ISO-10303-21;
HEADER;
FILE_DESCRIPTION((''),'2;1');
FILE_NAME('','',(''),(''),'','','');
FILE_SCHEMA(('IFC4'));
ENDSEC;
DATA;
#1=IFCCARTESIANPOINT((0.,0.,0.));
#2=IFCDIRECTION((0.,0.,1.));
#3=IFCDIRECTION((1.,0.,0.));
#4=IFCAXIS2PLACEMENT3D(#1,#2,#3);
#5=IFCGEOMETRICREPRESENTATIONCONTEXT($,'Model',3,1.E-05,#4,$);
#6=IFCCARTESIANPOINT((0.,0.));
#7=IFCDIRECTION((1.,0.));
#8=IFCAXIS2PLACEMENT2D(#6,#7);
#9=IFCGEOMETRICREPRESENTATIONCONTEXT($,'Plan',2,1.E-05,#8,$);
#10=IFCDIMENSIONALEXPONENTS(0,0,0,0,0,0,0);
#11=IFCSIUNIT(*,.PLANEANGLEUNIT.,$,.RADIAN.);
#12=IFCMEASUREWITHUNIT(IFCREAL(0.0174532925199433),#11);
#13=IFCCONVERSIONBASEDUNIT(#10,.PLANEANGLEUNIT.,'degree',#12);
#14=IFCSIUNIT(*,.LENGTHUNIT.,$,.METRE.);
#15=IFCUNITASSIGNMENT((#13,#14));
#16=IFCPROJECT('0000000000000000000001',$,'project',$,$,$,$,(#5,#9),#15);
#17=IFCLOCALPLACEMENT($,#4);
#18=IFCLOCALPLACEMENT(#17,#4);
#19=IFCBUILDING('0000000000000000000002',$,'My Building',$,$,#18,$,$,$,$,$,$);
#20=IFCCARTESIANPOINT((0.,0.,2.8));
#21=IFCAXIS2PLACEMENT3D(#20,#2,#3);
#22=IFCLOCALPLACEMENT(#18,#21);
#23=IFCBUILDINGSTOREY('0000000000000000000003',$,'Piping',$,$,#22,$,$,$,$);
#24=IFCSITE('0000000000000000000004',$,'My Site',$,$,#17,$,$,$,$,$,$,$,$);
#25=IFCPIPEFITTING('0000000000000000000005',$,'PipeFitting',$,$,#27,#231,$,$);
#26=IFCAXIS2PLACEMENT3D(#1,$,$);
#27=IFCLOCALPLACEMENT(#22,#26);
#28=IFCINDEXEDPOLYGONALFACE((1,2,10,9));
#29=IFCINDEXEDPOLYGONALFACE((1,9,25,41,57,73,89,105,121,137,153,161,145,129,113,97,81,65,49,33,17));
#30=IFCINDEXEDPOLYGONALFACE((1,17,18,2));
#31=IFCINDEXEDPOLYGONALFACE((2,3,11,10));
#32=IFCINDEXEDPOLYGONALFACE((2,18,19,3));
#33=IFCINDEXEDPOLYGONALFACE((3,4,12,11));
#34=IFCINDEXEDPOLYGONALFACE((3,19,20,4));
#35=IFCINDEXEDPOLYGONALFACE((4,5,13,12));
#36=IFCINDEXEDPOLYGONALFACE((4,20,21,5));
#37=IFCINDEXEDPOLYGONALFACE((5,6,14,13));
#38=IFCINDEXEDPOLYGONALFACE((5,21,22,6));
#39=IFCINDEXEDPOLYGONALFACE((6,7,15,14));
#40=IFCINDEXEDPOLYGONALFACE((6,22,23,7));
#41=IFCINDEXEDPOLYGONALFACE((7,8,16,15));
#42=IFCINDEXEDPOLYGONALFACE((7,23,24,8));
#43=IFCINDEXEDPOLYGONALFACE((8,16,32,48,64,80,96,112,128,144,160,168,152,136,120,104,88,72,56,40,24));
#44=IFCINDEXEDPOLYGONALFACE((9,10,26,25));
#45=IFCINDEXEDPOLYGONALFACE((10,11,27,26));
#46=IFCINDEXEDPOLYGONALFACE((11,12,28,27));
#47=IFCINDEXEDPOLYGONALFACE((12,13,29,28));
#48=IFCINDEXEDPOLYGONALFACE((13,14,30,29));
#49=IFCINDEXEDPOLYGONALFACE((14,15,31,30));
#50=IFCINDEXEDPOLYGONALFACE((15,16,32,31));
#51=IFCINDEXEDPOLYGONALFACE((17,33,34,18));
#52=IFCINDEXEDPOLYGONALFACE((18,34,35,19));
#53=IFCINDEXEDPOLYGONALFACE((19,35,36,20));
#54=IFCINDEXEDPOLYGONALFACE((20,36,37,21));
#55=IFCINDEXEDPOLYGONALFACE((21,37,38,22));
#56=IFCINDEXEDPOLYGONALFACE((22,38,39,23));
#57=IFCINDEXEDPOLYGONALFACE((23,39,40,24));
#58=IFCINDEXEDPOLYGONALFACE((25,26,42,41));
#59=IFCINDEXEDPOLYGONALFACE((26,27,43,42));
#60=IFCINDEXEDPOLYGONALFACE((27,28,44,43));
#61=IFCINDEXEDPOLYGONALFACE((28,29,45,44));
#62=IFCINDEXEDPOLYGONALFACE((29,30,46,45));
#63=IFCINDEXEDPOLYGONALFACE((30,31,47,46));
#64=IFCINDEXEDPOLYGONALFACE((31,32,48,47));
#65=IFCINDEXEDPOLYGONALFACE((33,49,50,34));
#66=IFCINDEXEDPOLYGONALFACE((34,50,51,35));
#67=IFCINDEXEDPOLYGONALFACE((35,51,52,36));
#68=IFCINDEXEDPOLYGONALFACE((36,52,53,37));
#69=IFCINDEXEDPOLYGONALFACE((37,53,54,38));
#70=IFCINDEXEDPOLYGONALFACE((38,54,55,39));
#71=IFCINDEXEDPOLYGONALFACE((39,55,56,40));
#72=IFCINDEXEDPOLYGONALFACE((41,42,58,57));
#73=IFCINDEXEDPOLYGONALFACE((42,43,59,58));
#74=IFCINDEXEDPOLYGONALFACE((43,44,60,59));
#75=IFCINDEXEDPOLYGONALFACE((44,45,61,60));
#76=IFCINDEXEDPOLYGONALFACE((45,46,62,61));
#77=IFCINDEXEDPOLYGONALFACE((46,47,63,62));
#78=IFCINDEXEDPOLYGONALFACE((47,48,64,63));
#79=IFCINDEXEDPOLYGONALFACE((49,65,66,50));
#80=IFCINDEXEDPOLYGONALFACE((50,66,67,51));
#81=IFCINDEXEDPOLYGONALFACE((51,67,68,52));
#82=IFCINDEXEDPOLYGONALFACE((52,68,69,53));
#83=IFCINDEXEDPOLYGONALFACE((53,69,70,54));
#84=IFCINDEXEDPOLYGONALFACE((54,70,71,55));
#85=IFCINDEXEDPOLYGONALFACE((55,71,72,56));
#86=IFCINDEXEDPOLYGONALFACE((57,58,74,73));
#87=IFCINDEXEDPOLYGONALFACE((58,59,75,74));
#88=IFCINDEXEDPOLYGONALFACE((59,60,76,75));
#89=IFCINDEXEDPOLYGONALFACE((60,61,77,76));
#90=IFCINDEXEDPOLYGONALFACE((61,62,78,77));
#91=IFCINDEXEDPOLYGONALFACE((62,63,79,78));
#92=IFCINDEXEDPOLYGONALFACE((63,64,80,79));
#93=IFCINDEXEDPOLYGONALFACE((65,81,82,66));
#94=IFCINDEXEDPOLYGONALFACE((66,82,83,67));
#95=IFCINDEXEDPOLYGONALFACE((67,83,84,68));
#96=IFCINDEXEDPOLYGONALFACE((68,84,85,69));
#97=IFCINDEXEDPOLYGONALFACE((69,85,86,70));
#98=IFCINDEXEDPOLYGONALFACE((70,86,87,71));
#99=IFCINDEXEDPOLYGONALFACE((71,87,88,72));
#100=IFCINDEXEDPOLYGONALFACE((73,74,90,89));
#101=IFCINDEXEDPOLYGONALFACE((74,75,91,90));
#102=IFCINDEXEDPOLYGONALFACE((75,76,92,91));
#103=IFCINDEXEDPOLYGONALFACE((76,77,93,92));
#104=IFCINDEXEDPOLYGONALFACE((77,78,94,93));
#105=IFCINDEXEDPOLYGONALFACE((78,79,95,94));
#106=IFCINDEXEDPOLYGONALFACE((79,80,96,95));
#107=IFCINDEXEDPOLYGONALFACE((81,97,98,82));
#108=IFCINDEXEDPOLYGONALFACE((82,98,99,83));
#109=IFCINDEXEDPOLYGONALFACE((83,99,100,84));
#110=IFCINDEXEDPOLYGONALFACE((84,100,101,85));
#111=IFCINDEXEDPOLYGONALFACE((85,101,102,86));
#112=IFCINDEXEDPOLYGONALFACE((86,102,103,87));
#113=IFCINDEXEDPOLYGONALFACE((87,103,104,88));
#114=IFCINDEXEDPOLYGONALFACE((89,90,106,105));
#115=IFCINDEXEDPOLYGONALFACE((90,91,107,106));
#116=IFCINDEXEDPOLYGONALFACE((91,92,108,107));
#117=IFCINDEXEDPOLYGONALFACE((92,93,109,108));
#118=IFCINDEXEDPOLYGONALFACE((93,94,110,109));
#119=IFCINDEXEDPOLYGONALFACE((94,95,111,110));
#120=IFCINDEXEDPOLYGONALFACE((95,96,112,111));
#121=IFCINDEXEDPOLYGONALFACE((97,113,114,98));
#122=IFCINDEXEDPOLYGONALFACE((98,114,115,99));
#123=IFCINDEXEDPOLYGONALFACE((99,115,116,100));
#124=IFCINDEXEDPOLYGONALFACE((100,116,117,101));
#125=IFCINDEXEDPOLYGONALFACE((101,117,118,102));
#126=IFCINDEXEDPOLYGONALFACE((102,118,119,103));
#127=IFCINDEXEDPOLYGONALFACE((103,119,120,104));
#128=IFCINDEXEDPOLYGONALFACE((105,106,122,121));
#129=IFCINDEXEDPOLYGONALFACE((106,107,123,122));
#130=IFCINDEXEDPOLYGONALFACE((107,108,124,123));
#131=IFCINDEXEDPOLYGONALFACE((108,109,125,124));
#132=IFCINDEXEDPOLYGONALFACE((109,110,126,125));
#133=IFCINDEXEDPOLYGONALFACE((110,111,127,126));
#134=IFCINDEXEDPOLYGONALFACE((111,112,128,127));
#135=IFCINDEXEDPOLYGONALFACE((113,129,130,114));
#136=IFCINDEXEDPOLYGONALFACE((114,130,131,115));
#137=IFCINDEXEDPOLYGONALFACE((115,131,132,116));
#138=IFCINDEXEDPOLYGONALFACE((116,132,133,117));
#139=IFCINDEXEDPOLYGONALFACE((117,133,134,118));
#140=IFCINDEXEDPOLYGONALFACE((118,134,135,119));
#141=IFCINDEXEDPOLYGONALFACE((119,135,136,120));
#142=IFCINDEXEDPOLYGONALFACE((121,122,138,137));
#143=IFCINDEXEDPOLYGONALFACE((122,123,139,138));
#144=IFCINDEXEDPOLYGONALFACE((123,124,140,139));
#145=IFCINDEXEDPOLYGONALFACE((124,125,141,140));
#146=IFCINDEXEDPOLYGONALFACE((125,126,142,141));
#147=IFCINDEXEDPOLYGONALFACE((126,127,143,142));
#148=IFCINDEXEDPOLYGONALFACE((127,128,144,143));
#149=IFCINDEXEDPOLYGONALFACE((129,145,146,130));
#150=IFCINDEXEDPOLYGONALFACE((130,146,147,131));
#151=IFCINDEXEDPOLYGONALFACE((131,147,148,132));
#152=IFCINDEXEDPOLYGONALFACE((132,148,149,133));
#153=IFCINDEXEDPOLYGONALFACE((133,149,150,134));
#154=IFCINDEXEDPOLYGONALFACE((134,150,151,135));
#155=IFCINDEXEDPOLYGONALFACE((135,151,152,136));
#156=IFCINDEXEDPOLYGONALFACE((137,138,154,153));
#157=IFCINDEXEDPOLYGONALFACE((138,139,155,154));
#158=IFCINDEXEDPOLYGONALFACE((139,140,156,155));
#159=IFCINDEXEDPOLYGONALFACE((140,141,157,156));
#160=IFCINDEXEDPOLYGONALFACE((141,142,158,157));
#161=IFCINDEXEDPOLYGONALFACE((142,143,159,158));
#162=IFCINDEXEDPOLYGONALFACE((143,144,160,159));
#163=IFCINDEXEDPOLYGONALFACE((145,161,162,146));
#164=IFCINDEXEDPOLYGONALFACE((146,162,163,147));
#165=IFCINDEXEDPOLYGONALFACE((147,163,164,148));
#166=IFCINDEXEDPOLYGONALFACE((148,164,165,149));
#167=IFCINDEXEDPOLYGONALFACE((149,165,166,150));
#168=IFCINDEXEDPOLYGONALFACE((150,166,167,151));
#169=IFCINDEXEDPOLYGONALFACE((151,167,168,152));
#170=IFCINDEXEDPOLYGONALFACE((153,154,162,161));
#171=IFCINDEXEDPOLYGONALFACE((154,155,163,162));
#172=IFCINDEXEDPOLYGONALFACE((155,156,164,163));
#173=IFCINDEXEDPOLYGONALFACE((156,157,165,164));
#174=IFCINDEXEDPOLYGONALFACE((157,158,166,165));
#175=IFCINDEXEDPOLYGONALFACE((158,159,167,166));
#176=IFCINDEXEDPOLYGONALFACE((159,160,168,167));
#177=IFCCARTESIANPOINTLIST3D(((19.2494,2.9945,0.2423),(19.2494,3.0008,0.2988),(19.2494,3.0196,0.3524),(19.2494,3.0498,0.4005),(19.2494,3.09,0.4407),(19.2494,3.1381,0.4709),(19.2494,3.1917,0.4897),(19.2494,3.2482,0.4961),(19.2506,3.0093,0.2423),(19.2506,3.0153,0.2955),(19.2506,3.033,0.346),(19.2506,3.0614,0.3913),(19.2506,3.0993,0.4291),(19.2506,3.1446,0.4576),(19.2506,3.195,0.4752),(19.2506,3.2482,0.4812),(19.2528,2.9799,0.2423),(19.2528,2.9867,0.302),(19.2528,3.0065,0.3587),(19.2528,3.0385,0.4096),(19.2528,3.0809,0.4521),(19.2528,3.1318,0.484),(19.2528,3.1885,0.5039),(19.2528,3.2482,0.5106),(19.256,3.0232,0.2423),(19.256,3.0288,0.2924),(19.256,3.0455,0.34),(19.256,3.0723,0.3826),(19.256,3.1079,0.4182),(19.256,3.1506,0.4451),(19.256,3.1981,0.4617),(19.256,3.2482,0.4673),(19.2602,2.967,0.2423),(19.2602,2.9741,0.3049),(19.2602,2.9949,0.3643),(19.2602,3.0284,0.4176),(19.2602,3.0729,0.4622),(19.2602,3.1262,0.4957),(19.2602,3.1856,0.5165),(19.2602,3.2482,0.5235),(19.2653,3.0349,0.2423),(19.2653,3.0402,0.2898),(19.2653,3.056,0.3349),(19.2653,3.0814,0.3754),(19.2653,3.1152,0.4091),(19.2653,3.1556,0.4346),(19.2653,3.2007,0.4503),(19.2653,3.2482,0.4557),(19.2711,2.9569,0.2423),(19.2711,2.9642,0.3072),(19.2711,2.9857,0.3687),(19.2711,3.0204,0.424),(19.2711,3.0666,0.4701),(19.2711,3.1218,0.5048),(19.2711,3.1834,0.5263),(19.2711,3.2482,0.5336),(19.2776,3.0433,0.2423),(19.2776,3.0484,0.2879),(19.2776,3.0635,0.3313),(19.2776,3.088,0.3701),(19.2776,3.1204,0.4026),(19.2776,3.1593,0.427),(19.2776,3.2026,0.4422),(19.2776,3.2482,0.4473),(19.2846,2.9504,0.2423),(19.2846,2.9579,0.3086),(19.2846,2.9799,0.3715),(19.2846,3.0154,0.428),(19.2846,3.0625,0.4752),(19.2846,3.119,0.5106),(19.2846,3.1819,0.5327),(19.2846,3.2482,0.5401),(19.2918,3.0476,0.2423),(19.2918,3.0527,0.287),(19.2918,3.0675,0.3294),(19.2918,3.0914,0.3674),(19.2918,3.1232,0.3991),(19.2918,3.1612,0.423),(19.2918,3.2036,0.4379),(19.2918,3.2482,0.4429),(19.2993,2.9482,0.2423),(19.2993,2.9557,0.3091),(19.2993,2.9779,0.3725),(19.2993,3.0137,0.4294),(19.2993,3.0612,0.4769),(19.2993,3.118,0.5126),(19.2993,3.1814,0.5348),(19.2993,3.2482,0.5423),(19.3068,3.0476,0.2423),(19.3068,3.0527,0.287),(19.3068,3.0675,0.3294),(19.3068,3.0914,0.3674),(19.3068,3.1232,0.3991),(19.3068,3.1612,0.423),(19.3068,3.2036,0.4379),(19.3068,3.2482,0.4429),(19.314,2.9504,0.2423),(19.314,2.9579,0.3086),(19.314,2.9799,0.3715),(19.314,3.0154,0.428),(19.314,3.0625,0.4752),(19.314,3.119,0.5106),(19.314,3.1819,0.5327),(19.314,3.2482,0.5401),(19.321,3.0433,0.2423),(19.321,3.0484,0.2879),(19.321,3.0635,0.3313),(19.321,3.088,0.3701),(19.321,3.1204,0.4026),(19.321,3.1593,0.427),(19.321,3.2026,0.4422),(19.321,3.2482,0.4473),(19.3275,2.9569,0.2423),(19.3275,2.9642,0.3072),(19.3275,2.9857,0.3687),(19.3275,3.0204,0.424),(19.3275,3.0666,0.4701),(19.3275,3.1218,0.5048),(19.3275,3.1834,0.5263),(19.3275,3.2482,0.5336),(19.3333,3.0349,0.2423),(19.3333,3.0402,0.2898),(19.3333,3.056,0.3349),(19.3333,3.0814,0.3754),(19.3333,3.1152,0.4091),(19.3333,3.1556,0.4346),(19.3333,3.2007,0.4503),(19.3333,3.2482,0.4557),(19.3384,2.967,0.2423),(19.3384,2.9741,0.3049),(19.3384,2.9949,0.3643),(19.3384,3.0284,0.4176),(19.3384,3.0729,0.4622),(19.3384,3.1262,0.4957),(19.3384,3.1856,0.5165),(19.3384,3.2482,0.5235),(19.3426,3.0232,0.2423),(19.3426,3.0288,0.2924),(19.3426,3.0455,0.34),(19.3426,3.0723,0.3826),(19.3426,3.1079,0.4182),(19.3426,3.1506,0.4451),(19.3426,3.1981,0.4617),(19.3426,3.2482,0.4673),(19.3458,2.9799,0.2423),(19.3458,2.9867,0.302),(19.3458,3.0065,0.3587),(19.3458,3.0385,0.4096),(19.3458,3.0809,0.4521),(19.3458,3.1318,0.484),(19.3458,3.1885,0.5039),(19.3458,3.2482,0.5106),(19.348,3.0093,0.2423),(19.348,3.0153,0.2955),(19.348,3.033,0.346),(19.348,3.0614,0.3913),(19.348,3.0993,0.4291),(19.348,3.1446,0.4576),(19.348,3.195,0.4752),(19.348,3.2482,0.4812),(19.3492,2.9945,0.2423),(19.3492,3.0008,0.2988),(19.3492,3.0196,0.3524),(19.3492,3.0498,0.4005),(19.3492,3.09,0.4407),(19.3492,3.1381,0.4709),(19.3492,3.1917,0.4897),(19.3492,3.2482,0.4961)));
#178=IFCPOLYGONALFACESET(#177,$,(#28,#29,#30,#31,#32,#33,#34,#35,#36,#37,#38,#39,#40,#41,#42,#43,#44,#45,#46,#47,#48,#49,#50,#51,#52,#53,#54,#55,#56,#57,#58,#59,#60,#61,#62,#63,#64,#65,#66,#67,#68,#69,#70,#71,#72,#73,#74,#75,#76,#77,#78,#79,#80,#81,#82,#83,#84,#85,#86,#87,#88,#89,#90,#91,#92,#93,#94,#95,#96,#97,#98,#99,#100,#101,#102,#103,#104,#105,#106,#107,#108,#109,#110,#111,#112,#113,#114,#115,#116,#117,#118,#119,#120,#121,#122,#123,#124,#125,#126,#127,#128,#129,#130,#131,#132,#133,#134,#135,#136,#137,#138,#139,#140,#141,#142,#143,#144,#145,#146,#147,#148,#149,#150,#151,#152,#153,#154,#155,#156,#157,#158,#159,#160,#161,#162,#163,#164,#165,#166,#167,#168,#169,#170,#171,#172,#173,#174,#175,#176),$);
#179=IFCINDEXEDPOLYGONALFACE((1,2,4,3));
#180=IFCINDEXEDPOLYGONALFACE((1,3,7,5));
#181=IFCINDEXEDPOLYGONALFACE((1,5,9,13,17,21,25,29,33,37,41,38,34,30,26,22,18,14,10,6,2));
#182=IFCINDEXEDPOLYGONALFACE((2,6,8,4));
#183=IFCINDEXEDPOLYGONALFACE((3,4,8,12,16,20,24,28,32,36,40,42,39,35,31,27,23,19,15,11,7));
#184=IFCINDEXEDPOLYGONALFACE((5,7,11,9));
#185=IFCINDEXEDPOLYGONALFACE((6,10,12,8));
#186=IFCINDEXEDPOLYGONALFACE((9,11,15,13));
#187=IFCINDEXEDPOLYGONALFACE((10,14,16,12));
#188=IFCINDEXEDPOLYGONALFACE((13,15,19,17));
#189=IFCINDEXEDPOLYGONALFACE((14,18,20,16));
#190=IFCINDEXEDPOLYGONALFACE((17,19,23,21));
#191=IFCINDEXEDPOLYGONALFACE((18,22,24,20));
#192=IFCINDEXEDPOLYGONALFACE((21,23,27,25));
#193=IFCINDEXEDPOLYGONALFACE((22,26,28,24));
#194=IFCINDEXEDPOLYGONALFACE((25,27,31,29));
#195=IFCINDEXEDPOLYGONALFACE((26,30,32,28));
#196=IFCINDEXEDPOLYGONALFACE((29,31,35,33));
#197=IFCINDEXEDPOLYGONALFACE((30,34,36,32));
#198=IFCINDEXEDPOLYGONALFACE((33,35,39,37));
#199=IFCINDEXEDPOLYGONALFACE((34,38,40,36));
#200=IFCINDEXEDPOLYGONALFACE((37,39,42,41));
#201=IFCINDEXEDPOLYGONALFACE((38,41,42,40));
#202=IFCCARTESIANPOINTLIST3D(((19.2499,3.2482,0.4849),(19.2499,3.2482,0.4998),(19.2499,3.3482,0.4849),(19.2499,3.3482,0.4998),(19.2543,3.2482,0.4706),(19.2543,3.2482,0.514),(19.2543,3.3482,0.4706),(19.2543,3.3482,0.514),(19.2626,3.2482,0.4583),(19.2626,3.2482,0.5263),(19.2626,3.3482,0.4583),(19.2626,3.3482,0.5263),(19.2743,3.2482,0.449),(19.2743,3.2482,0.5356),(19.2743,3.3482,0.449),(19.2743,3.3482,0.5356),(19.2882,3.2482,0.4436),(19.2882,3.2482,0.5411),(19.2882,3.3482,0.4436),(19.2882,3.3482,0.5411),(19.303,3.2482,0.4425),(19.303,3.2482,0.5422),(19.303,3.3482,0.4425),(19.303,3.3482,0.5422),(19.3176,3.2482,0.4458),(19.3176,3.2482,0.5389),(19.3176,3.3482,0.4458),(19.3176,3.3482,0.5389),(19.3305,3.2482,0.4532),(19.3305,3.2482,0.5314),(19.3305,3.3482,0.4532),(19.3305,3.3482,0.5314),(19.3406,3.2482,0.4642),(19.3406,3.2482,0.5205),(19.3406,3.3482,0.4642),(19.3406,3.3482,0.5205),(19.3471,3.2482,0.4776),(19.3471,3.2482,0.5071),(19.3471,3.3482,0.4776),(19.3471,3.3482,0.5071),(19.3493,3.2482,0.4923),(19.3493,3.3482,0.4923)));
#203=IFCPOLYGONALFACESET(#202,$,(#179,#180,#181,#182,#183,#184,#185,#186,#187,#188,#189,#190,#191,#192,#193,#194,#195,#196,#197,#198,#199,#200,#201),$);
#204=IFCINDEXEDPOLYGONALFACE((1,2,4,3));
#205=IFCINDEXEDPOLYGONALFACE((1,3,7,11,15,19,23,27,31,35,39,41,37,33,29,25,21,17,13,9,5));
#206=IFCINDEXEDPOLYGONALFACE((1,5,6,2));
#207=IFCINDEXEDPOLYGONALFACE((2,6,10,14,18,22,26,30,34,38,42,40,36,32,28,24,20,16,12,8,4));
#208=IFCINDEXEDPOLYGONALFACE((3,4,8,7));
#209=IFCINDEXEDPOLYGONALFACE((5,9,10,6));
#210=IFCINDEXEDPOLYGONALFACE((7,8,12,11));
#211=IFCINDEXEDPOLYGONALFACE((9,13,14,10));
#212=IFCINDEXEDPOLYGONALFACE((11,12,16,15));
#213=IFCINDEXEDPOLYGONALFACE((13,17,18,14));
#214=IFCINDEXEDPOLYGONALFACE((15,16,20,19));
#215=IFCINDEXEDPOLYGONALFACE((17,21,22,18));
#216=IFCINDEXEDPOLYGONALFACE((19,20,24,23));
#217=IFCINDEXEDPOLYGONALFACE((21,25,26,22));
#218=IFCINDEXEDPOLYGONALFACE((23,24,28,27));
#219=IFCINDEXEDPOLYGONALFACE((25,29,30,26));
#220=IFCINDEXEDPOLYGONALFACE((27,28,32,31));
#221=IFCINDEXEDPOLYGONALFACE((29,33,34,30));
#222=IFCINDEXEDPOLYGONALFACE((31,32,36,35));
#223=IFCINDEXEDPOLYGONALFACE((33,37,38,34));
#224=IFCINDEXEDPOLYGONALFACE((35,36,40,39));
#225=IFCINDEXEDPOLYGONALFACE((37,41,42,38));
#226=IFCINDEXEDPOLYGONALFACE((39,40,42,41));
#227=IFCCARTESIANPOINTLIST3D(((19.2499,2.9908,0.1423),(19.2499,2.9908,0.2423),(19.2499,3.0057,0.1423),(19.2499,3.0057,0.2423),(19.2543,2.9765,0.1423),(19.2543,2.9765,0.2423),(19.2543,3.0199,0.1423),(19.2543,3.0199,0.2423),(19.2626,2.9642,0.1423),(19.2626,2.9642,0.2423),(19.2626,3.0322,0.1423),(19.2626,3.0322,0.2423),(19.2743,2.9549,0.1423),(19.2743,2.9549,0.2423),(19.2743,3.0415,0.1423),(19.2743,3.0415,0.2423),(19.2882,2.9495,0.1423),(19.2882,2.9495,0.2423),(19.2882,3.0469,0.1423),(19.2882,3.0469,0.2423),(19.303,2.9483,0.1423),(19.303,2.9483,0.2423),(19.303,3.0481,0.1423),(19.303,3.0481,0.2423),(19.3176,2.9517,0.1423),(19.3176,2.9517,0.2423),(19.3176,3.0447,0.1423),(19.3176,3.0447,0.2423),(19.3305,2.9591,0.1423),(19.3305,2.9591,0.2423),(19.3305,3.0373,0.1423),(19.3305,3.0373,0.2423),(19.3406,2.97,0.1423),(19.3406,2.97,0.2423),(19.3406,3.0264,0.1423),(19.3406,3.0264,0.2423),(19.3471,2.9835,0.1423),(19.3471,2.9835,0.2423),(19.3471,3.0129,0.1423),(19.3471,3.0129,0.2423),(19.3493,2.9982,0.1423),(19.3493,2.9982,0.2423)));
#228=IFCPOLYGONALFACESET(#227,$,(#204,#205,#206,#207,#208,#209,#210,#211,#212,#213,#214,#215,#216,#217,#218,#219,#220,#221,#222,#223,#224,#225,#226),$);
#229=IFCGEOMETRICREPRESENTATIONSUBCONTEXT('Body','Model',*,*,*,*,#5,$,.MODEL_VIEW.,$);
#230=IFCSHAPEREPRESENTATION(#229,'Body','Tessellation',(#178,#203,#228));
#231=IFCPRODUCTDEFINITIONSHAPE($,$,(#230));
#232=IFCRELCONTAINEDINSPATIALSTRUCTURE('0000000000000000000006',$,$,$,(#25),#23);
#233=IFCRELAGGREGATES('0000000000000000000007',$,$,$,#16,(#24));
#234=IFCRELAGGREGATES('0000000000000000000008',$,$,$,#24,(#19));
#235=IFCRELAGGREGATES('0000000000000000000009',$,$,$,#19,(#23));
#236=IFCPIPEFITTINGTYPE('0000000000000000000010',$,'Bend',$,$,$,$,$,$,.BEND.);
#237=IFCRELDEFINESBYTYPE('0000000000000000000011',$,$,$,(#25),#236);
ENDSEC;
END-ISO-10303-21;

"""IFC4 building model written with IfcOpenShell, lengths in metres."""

from ifc_helpers import new_model, entity, si_unit, converted_unit, frame, origin_with_axes, origin_2d_with_axis, place, context, subcontext, project, spatial, circle, extrude, source, transform, mapped, type_object, type_shapes, element, save


model = new_model("IFC4")

# Units and contexts
model_context = context("Model", 3, precision=1e-05, world=origin_with_axes())
plan_context = context("Plan", 2, precision=1e-05, world=origin_2d_with_axis())
body_context = subcontext(model_context, "Body", "Model", "MODEL_VIEW")
ifc_project = project(units=[converted_unit("PLANEANGLEUNIT", "degree", entity("IfcReal", 0.0174532925199433), si_unit("PLANEANGLEUNIT", "RADIAN"), dimensions=[0, 0, 0, 0, 0, 0, 0]), si_unit("LENGTHUNIT", "METRE")], contexts=[model_context, plan_context])

# Site, building, storey
site_placement = place(None, origin_with_axes())
site = spatial("IfcSite", under=ifc_project, at=site_placement, Name="My Site")
building_placement = place(site_placement, origin_with_axes())
building = spatial("IfcBuilding", under=site, at=building_placement, Name="My Building")
storey_placement = place(building_placement, frame((0.0, 0.0, 2.8), z_axis=(0.0, 0.0, 1.0), x_axis=(1.0, 0.0, 0.0)))
storey = spatial("IfcBuildingStorey", under=building, at=storey_placement, Name="Piping")

# Pipe fitting
pipe_fitting_type_1 = type_object("IfcPipeFittingType", Name="Bend", PredefinedType="BEND")
shared_shape_1 = source(origin_with_axes(), body_context, "Body", "SolidModel", [
    entity("IfcSweptDiskSolid", entity("IfcIndexedPolyCurve", entity("IfcCartesianPointList3D", [[0.0, 0.0, 0.1], [0.0, -0.0732, 0.2768], [0.0, -0.25, 0.35]]), [entity("IfcArcIndex", [1, 2, 3])]), 0.05),
    extrude(circle(Radius=0.05), origin_with_axes(), (0.0, 0.0, 1.0), 0.1),
    extrude(circle(Radius=0.05), frame((0.0, -0.25, 0.35), z_axis=(0.0, -1.0, 0.0), x_axis=(1.0, 0.0, 0.0)), (0.0, 0.0, 1.0), 0.1),
])
type_shapes(pipe_fitting_type_1, [shared_shape_1])
for number, where, z_axis, x_axis, name in (
    (1, (19.2993, 3.3482, 0.4923), (0.0, -1.0, 0.0), (1.0, 0.0, 0.0), "PipeFitting"),
):
    element("IfcPipeFitting", number, at=place(storey_placement, frame(where, z_axis=z_axis, x_axis=x_axis)), inside=storey, type_object=pipe_fitting_type_1, Name=name, context=body_context, shape_type="MappedRepresentation", body=[
        mapped(shared_shape_1, transform((0.0, 0.0, 0.0), x_axis=(1.0, 0.0, 0.0), y_axis=(0.0, 1.0, 0.0), z_axis=(0.0, 0.0, 1.0), scale=1.0)),
    ])

save(model, "model.ifc")
